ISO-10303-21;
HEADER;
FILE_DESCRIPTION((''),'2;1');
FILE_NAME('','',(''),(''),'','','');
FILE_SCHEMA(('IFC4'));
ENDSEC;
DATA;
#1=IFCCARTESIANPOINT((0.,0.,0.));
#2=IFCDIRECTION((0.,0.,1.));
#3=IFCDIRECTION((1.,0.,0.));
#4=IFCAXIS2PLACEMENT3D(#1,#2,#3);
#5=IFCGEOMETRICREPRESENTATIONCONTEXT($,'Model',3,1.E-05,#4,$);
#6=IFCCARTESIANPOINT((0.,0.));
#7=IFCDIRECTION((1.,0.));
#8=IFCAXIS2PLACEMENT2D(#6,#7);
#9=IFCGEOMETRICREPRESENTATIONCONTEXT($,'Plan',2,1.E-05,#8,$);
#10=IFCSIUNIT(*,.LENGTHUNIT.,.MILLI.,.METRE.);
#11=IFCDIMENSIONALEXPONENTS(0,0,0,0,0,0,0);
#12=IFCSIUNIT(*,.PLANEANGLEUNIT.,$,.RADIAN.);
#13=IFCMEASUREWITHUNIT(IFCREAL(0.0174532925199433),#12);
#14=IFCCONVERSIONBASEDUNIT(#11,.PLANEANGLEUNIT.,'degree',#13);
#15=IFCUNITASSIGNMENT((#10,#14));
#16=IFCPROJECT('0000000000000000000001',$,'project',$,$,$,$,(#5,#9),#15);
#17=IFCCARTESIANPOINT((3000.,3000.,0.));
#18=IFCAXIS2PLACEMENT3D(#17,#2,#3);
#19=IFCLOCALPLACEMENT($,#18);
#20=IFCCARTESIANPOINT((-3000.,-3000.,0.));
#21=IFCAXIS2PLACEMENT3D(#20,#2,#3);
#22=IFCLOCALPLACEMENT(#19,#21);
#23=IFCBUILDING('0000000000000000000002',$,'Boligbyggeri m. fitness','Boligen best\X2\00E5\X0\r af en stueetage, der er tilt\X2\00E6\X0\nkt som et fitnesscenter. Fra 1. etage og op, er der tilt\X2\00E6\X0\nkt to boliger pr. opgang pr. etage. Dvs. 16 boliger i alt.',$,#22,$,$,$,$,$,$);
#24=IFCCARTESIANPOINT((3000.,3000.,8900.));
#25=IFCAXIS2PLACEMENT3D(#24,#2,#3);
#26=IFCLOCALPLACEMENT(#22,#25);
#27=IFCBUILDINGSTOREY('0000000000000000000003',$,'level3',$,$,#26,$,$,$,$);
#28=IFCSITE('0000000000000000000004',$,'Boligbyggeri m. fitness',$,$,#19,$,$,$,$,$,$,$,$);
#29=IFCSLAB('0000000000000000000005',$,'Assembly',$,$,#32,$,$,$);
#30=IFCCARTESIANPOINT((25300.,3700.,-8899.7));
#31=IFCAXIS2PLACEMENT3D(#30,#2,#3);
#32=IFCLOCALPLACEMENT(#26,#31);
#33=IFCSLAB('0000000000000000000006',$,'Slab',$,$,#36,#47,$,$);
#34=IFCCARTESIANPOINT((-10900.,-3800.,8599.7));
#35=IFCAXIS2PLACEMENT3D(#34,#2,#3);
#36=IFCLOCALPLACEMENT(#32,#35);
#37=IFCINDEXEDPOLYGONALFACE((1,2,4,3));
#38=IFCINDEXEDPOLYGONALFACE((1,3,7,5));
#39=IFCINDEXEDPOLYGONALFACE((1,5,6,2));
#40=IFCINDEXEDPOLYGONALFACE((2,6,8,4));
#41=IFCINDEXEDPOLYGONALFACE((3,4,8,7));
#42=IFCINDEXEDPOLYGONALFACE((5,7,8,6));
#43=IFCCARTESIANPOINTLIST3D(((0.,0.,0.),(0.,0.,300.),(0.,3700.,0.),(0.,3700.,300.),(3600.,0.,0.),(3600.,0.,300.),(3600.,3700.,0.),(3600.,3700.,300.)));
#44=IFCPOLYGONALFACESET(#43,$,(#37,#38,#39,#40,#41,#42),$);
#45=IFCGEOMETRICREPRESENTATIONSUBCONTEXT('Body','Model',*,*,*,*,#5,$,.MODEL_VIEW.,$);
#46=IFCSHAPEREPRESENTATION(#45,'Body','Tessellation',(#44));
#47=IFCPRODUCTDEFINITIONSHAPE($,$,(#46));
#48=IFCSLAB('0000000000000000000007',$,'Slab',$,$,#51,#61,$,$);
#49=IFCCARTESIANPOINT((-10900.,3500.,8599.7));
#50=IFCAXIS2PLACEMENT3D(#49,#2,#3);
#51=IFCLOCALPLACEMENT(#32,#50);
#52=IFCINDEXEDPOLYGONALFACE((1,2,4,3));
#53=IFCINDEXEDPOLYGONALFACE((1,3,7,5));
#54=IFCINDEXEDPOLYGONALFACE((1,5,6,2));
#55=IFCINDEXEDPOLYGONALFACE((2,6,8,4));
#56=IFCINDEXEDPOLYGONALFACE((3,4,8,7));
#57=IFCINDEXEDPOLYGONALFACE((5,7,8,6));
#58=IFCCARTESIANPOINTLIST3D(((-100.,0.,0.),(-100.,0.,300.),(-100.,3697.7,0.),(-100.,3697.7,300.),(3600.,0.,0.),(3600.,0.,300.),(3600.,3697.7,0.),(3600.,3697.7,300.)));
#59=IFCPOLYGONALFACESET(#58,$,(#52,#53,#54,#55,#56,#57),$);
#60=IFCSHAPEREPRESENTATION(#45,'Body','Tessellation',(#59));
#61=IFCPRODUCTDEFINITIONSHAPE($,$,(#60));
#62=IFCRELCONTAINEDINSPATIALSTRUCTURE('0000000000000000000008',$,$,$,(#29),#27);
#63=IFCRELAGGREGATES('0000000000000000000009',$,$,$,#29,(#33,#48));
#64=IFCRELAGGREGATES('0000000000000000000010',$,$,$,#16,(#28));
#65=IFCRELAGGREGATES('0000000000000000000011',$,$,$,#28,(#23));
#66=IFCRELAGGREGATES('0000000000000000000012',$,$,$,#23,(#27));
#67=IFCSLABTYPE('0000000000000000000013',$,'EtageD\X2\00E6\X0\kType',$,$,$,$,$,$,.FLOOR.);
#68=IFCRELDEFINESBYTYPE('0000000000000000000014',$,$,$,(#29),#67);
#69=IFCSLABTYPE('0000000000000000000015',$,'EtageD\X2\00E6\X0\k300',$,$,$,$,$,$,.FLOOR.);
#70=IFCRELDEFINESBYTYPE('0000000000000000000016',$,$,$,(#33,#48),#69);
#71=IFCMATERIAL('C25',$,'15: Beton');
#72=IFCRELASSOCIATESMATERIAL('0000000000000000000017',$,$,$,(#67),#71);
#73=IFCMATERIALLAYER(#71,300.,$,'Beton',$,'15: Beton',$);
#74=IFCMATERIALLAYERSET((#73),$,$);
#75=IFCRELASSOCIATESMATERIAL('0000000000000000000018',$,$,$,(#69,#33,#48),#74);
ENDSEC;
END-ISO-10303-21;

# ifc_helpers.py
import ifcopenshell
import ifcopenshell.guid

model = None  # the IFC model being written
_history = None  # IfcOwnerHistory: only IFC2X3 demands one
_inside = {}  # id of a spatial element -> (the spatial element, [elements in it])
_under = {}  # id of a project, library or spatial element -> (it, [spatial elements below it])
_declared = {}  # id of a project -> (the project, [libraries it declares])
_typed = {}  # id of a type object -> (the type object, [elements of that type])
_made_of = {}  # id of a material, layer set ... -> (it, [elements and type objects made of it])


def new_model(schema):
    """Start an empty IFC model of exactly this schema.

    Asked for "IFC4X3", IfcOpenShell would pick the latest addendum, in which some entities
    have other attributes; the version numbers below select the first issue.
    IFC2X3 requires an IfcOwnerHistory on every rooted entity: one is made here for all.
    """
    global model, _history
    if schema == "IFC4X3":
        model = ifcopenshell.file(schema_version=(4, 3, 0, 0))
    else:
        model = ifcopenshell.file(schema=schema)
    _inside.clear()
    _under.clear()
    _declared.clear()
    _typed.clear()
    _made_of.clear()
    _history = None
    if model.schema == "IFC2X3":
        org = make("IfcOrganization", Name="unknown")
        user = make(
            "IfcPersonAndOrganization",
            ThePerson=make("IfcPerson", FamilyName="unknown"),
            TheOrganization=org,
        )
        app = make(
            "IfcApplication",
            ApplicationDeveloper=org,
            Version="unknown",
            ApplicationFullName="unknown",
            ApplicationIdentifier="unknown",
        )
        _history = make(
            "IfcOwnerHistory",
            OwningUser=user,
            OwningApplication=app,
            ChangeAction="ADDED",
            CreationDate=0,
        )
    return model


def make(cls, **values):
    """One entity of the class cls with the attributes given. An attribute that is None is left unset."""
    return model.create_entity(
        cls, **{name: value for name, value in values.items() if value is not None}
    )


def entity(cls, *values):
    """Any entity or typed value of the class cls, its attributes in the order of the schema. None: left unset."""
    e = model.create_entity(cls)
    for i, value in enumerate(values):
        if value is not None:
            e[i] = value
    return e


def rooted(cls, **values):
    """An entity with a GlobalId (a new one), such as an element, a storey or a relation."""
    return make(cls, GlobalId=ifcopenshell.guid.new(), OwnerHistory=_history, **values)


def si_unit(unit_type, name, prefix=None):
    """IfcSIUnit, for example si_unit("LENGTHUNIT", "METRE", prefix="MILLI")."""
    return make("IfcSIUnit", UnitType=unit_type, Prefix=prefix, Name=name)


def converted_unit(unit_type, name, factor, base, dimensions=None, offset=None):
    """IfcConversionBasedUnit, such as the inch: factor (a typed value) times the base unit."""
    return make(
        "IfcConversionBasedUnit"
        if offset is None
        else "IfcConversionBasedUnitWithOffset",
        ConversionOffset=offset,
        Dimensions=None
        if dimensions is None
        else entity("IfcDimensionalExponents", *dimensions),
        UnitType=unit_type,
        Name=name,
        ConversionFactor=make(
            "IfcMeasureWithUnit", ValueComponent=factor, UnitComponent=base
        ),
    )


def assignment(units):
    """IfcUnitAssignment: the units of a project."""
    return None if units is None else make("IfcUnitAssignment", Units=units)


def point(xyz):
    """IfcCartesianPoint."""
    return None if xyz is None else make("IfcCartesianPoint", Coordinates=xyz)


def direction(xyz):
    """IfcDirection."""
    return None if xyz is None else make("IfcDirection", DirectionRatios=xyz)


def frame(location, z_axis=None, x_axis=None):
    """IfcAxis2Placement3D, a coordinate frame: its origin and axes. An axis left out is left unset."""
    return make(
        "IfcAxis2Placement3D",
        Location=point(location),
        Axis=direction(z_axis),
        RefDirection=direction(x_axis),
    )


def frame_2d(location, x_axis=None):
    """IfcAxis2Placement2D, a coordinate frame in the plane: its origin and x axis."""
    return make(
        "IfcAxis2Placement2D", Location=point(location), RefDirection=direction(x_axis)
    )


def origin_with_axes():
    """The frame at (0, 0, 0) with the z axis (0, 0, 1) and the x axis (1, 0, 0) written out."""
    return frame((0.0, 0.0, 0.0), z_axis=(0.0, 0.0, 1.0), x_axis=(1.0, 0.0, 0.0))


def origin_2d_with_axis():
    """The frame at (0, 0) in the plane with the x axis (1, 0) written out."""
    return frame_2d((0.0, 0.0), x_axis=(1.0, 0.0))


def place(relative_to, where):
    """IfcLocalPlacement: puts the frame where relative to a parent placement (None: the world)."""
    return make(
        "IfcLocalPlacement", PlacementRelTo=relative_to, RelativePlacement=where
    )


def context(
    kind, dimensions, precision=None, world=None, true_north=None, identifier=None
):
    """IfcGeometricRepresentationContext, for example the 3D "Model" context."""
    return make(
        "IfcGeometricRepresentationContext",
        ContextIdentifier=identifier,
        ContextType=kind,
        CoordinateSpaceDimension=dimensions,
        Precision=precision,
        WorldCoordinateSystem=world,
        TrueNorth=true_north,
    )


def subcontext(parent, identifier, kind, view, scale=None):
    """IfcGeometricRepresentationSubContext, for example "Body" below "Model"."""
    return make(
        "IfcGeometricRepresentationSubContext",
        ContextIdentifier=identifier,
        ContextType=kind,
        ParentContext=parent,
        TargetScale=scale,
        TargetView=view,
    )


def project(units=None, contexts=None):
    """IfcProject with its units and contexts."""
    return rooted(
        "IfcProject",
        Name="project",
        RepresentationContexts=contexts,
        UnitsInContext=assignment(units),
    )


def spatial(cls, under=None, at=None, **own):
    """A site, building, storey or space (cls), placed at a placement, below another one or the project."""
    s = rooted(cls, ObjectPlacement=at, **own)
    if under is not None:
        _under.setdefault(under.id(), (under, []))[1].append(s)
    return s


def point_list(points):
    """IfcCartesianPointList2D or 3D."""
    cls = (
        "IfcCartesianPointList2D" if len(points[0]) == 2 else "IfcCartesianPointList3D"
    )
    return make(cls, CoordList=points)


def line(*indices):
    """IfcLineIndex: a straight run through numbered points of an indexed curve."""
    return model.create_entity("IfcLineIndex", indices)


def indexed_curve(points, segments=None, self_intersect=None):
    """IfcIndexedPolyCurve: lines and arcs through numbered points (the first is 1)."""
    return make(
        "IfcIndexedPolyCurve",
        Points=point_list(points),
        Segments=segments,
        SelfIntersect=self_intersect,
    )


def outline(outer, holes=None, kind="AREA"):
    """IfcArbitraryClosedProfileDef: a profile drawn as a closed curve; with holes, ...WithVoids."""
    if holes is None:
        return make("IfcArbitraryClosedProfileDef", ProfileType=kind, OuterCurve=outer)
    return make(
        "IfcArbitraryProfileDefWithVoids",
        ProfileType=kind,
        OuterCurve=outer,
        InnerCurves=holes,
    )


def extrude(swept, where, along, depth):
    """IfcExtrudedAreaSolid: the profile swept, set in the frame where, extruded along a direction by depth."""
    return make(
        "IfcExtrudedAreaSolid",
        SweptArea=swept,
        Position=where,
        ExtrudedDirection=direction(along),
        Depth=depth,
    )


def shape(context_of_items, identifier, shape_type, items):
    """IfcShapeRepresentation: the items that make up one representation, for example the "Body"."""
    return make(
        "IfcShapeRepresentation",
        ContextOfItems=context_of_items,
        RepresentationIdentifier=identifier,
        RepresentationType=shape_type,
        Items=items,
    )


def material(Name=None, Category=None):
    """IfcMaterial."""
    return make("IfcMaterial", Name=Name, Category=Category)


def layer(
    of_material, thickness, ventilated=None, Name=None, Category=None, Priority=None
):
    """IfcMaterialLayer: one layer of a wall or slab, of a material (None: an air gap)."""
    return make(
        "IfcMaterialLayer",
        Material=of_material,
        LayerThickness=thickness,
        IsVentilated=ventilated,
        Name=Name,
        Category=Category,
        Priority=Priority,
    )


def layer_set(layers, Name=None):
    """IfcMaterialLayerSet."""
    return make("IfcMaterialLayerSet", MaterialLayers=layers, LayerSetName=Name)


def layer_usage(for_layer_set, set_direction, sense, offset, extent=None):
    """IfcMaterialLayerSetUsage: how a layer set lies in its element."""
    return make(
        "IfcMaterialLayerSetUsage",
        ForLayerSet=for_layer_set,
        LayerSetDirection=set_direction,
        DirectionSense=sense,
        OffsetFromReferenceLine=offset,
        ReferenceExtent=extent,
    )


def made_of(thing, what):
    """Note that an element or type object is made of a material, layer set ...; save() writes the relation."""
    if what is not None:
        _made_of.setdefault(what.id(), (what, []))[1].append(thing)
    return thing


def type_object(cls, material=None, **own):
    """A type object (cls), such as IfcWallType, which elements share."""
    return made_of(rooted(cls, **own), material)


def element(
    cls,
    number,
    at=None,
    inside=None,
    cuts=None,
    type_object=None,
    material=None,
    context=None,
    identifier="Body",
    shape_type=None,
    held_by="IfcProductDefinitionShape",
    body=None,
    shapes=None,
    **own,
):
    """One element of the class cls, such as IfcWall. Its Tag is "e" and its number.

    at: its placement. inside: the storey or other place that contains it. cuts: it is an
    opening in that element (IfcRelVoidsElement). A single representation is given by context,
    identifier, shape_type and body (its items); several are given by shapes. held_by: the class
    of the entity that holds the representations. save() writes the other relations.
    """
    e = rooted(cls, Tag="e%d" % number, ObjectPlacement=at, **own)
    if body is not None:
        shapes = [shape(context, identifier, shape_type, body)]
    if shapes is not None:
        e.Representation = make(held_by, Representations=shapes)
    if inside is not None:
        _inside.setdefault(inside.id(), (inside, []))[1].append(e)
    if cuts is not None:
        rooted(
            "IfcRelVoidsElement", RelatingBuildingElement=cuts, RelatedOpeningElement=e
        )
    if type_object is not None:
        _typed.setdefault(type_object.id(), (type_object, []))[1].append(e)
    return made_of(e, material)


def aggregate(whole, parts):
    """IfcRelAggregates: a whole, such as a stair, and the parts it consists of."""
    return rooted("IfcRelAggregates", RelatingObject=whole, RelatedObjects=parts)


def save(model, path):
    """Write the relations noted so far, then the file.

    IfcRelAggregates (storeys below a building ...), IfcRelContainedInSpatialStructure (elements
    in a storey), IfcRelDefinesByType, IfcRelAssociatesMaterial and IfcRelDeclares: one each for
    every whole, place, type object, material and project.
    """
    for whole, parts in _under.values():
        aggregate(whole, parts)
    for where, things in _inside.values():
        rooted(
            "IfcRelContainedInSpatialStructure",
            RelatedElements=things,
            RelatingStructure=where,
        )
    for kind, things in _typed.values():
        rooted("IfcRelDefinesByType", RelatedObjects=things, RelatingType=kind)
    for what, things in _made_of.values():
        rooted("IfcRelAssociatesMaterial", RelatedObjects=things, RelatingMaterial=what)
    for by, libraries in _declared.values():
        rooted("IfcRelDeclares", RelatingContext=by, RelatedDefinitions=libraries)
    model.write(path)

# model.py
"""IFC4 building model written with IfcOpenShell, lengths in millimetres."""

from ifc_helpers import new_model, entity, si_unit, converted_unit, frame, origin_with_axes, origin_2d_with_axis, place, context, subcontext, project, spatial, line, indexed_curve, outline, extrude, material, layer, layer_set, layer_usage, type_object, element, aggregate, save


model = new_model("IFC4")

# Units and contexts
model_context = context("Model", 3, precision=1e-05, world=origin_with_axes())
plan_context = context("Plan", 2, precision=1e-05, world=origin_2d_with_axis())
body_context = subcontext(model_context, "Body", "Model", "MODEL_VIEW")
ifc_project = project(units=[si_unit("LENGTHUNIT", "METRE", prefix="MILLI"), converted_unit("PLANEANGLEUNIT", "degree", entity("IfcReal", 0.0174532925199433), si_unit("PLANEANGLEUNIT", "RADIAN"), dimensions=[0, 0, 0, 0, 0, 0, 0])], contexts=[model_context, plan_context])

# Site, building, storey
site_placement = place(None, frame((3000.0, 3000.0, 0.0), z_axis=(0.0, 0.0, 1.0), x_axis=(1.0, 0.0, 0.0)))
site = spatial("IfcSite", under=ifc_project, at=site_placement, Name="Boligbyggeri m. fitness")
building_placement = place(site_placement, frame((-3000.0, -3000.0, 0.0), z_axis=(0.0, 0.0, 1.0), x_axis=(1.0, 0.0, 0.0)))
building = spatial("IfcBuilding", under=site, at=building_placement, Name="Boligbyggeri m. fitness", Description="Boligen består af en stueetage, der er tiltænkt som et fitnesscenter. Fra 1. etage og op, er der tiltænkt to boliger pr. opgang pr. etage. Dvs. 16 boliger i alt.")
storey_placement = place(building_placement, frame((3000.0, 3000.0, 8900.0), z_axis=(0.0, 0.0, 1.0), x_axis=(1.0, 0.0, 0.0)))
storey = spatial("IfcBuildingStorey", under=building, at=storey_placement, Name="level3")

# Shared definitions
ifc_material_1 = material(Name="C25", Category="15: Beton")

# Slabs
slab_type_1 = type_object("IfcSlabType", Name="EtageDækType", PredefinedType="FLOOR", material=ifc_material_1)
slab_1_placement = place(storey_placement, frame((25300.0, 3700.0, -8899.7), z_axis=(0.0, 0.0, 1.0), x_axis=(1.0, 0.0, 0.0)))
slab_1 = element("IfcSlab", 1, at=slab_1_placement, inside=storey, type_object=slab_type_1, Name="Assembly")
ifc_layer = layer(ifc_material_1, 300.0, Name="Beton", Category="15: Beton")
ifc_layer_set = layer_set([ifc_layer])
ifc_layer_usage_1 = layer_usage(ifc_layer_set, "AXIS3", "POSITIVE", 0.0)
slab_type_2 = type_object("IfcSlabType", Name="EtageDæk300", PredefinedType="FLOOR", material=ifc_layer_set)
slab_2_placement = place(slab_1_placement, frame((-10900.0, -3800.0, 8599.7), z_axis=(0.0, 0.0, 1.0), x_axis=(1.0, 0.0, 0.0)))
slab_2 = element("IfcSlab", 2, at=slab_2_placement, type_object=slab_type_2, material=ifc_layer_usage_1, Name="Slab", context=body_context, shape_type="SweptSolid", body=[
    extrude(outline(indexed_curve([(0.0, 0.0), (3600.0, 0.0), (3600.0, 3700.0), (0.0, 3700.0)], segments=[line(3, 2), line(2, 1), line(1, 4), line(4, 3)], self_intersect=False)), None, (0.0, 0.0, 1.0), 300.0),
])
ifc_layer_usage_2 = layer_usage(ifc_layer_set, "AXIS3", "POSITIVE", 0.0)
slab_3_placement = place(slab_1_placement, frame((-10900.0, 3500.0, 8599.7), z_axis=(0.0, 0.0, 1.0), x_axis=(1.0, 0.0, 0.0)))
slab_3 = element("IfcSlab", 3, at=slab_3_placement, type_object=slab_type_2, material=ifc_layer_usage_2, Name="Slab", context=body_context, shape_type="SweptSolid", body=[
    extrude(outline(indexed_curve([(3600.0, 3697.7), (3600.0, 0.0), (-100.0, 0.0), (-100.0, 3697.7)], segments=[line(3, 2), line(2, 1), line(1, 4), line(4, 3)], self_intersect=False)), None, (0.0, 0.0, 1.0), 300.0),
])
aggregate(slab_1, [slab_2, slab_3])

save(model, "model.ifc")
